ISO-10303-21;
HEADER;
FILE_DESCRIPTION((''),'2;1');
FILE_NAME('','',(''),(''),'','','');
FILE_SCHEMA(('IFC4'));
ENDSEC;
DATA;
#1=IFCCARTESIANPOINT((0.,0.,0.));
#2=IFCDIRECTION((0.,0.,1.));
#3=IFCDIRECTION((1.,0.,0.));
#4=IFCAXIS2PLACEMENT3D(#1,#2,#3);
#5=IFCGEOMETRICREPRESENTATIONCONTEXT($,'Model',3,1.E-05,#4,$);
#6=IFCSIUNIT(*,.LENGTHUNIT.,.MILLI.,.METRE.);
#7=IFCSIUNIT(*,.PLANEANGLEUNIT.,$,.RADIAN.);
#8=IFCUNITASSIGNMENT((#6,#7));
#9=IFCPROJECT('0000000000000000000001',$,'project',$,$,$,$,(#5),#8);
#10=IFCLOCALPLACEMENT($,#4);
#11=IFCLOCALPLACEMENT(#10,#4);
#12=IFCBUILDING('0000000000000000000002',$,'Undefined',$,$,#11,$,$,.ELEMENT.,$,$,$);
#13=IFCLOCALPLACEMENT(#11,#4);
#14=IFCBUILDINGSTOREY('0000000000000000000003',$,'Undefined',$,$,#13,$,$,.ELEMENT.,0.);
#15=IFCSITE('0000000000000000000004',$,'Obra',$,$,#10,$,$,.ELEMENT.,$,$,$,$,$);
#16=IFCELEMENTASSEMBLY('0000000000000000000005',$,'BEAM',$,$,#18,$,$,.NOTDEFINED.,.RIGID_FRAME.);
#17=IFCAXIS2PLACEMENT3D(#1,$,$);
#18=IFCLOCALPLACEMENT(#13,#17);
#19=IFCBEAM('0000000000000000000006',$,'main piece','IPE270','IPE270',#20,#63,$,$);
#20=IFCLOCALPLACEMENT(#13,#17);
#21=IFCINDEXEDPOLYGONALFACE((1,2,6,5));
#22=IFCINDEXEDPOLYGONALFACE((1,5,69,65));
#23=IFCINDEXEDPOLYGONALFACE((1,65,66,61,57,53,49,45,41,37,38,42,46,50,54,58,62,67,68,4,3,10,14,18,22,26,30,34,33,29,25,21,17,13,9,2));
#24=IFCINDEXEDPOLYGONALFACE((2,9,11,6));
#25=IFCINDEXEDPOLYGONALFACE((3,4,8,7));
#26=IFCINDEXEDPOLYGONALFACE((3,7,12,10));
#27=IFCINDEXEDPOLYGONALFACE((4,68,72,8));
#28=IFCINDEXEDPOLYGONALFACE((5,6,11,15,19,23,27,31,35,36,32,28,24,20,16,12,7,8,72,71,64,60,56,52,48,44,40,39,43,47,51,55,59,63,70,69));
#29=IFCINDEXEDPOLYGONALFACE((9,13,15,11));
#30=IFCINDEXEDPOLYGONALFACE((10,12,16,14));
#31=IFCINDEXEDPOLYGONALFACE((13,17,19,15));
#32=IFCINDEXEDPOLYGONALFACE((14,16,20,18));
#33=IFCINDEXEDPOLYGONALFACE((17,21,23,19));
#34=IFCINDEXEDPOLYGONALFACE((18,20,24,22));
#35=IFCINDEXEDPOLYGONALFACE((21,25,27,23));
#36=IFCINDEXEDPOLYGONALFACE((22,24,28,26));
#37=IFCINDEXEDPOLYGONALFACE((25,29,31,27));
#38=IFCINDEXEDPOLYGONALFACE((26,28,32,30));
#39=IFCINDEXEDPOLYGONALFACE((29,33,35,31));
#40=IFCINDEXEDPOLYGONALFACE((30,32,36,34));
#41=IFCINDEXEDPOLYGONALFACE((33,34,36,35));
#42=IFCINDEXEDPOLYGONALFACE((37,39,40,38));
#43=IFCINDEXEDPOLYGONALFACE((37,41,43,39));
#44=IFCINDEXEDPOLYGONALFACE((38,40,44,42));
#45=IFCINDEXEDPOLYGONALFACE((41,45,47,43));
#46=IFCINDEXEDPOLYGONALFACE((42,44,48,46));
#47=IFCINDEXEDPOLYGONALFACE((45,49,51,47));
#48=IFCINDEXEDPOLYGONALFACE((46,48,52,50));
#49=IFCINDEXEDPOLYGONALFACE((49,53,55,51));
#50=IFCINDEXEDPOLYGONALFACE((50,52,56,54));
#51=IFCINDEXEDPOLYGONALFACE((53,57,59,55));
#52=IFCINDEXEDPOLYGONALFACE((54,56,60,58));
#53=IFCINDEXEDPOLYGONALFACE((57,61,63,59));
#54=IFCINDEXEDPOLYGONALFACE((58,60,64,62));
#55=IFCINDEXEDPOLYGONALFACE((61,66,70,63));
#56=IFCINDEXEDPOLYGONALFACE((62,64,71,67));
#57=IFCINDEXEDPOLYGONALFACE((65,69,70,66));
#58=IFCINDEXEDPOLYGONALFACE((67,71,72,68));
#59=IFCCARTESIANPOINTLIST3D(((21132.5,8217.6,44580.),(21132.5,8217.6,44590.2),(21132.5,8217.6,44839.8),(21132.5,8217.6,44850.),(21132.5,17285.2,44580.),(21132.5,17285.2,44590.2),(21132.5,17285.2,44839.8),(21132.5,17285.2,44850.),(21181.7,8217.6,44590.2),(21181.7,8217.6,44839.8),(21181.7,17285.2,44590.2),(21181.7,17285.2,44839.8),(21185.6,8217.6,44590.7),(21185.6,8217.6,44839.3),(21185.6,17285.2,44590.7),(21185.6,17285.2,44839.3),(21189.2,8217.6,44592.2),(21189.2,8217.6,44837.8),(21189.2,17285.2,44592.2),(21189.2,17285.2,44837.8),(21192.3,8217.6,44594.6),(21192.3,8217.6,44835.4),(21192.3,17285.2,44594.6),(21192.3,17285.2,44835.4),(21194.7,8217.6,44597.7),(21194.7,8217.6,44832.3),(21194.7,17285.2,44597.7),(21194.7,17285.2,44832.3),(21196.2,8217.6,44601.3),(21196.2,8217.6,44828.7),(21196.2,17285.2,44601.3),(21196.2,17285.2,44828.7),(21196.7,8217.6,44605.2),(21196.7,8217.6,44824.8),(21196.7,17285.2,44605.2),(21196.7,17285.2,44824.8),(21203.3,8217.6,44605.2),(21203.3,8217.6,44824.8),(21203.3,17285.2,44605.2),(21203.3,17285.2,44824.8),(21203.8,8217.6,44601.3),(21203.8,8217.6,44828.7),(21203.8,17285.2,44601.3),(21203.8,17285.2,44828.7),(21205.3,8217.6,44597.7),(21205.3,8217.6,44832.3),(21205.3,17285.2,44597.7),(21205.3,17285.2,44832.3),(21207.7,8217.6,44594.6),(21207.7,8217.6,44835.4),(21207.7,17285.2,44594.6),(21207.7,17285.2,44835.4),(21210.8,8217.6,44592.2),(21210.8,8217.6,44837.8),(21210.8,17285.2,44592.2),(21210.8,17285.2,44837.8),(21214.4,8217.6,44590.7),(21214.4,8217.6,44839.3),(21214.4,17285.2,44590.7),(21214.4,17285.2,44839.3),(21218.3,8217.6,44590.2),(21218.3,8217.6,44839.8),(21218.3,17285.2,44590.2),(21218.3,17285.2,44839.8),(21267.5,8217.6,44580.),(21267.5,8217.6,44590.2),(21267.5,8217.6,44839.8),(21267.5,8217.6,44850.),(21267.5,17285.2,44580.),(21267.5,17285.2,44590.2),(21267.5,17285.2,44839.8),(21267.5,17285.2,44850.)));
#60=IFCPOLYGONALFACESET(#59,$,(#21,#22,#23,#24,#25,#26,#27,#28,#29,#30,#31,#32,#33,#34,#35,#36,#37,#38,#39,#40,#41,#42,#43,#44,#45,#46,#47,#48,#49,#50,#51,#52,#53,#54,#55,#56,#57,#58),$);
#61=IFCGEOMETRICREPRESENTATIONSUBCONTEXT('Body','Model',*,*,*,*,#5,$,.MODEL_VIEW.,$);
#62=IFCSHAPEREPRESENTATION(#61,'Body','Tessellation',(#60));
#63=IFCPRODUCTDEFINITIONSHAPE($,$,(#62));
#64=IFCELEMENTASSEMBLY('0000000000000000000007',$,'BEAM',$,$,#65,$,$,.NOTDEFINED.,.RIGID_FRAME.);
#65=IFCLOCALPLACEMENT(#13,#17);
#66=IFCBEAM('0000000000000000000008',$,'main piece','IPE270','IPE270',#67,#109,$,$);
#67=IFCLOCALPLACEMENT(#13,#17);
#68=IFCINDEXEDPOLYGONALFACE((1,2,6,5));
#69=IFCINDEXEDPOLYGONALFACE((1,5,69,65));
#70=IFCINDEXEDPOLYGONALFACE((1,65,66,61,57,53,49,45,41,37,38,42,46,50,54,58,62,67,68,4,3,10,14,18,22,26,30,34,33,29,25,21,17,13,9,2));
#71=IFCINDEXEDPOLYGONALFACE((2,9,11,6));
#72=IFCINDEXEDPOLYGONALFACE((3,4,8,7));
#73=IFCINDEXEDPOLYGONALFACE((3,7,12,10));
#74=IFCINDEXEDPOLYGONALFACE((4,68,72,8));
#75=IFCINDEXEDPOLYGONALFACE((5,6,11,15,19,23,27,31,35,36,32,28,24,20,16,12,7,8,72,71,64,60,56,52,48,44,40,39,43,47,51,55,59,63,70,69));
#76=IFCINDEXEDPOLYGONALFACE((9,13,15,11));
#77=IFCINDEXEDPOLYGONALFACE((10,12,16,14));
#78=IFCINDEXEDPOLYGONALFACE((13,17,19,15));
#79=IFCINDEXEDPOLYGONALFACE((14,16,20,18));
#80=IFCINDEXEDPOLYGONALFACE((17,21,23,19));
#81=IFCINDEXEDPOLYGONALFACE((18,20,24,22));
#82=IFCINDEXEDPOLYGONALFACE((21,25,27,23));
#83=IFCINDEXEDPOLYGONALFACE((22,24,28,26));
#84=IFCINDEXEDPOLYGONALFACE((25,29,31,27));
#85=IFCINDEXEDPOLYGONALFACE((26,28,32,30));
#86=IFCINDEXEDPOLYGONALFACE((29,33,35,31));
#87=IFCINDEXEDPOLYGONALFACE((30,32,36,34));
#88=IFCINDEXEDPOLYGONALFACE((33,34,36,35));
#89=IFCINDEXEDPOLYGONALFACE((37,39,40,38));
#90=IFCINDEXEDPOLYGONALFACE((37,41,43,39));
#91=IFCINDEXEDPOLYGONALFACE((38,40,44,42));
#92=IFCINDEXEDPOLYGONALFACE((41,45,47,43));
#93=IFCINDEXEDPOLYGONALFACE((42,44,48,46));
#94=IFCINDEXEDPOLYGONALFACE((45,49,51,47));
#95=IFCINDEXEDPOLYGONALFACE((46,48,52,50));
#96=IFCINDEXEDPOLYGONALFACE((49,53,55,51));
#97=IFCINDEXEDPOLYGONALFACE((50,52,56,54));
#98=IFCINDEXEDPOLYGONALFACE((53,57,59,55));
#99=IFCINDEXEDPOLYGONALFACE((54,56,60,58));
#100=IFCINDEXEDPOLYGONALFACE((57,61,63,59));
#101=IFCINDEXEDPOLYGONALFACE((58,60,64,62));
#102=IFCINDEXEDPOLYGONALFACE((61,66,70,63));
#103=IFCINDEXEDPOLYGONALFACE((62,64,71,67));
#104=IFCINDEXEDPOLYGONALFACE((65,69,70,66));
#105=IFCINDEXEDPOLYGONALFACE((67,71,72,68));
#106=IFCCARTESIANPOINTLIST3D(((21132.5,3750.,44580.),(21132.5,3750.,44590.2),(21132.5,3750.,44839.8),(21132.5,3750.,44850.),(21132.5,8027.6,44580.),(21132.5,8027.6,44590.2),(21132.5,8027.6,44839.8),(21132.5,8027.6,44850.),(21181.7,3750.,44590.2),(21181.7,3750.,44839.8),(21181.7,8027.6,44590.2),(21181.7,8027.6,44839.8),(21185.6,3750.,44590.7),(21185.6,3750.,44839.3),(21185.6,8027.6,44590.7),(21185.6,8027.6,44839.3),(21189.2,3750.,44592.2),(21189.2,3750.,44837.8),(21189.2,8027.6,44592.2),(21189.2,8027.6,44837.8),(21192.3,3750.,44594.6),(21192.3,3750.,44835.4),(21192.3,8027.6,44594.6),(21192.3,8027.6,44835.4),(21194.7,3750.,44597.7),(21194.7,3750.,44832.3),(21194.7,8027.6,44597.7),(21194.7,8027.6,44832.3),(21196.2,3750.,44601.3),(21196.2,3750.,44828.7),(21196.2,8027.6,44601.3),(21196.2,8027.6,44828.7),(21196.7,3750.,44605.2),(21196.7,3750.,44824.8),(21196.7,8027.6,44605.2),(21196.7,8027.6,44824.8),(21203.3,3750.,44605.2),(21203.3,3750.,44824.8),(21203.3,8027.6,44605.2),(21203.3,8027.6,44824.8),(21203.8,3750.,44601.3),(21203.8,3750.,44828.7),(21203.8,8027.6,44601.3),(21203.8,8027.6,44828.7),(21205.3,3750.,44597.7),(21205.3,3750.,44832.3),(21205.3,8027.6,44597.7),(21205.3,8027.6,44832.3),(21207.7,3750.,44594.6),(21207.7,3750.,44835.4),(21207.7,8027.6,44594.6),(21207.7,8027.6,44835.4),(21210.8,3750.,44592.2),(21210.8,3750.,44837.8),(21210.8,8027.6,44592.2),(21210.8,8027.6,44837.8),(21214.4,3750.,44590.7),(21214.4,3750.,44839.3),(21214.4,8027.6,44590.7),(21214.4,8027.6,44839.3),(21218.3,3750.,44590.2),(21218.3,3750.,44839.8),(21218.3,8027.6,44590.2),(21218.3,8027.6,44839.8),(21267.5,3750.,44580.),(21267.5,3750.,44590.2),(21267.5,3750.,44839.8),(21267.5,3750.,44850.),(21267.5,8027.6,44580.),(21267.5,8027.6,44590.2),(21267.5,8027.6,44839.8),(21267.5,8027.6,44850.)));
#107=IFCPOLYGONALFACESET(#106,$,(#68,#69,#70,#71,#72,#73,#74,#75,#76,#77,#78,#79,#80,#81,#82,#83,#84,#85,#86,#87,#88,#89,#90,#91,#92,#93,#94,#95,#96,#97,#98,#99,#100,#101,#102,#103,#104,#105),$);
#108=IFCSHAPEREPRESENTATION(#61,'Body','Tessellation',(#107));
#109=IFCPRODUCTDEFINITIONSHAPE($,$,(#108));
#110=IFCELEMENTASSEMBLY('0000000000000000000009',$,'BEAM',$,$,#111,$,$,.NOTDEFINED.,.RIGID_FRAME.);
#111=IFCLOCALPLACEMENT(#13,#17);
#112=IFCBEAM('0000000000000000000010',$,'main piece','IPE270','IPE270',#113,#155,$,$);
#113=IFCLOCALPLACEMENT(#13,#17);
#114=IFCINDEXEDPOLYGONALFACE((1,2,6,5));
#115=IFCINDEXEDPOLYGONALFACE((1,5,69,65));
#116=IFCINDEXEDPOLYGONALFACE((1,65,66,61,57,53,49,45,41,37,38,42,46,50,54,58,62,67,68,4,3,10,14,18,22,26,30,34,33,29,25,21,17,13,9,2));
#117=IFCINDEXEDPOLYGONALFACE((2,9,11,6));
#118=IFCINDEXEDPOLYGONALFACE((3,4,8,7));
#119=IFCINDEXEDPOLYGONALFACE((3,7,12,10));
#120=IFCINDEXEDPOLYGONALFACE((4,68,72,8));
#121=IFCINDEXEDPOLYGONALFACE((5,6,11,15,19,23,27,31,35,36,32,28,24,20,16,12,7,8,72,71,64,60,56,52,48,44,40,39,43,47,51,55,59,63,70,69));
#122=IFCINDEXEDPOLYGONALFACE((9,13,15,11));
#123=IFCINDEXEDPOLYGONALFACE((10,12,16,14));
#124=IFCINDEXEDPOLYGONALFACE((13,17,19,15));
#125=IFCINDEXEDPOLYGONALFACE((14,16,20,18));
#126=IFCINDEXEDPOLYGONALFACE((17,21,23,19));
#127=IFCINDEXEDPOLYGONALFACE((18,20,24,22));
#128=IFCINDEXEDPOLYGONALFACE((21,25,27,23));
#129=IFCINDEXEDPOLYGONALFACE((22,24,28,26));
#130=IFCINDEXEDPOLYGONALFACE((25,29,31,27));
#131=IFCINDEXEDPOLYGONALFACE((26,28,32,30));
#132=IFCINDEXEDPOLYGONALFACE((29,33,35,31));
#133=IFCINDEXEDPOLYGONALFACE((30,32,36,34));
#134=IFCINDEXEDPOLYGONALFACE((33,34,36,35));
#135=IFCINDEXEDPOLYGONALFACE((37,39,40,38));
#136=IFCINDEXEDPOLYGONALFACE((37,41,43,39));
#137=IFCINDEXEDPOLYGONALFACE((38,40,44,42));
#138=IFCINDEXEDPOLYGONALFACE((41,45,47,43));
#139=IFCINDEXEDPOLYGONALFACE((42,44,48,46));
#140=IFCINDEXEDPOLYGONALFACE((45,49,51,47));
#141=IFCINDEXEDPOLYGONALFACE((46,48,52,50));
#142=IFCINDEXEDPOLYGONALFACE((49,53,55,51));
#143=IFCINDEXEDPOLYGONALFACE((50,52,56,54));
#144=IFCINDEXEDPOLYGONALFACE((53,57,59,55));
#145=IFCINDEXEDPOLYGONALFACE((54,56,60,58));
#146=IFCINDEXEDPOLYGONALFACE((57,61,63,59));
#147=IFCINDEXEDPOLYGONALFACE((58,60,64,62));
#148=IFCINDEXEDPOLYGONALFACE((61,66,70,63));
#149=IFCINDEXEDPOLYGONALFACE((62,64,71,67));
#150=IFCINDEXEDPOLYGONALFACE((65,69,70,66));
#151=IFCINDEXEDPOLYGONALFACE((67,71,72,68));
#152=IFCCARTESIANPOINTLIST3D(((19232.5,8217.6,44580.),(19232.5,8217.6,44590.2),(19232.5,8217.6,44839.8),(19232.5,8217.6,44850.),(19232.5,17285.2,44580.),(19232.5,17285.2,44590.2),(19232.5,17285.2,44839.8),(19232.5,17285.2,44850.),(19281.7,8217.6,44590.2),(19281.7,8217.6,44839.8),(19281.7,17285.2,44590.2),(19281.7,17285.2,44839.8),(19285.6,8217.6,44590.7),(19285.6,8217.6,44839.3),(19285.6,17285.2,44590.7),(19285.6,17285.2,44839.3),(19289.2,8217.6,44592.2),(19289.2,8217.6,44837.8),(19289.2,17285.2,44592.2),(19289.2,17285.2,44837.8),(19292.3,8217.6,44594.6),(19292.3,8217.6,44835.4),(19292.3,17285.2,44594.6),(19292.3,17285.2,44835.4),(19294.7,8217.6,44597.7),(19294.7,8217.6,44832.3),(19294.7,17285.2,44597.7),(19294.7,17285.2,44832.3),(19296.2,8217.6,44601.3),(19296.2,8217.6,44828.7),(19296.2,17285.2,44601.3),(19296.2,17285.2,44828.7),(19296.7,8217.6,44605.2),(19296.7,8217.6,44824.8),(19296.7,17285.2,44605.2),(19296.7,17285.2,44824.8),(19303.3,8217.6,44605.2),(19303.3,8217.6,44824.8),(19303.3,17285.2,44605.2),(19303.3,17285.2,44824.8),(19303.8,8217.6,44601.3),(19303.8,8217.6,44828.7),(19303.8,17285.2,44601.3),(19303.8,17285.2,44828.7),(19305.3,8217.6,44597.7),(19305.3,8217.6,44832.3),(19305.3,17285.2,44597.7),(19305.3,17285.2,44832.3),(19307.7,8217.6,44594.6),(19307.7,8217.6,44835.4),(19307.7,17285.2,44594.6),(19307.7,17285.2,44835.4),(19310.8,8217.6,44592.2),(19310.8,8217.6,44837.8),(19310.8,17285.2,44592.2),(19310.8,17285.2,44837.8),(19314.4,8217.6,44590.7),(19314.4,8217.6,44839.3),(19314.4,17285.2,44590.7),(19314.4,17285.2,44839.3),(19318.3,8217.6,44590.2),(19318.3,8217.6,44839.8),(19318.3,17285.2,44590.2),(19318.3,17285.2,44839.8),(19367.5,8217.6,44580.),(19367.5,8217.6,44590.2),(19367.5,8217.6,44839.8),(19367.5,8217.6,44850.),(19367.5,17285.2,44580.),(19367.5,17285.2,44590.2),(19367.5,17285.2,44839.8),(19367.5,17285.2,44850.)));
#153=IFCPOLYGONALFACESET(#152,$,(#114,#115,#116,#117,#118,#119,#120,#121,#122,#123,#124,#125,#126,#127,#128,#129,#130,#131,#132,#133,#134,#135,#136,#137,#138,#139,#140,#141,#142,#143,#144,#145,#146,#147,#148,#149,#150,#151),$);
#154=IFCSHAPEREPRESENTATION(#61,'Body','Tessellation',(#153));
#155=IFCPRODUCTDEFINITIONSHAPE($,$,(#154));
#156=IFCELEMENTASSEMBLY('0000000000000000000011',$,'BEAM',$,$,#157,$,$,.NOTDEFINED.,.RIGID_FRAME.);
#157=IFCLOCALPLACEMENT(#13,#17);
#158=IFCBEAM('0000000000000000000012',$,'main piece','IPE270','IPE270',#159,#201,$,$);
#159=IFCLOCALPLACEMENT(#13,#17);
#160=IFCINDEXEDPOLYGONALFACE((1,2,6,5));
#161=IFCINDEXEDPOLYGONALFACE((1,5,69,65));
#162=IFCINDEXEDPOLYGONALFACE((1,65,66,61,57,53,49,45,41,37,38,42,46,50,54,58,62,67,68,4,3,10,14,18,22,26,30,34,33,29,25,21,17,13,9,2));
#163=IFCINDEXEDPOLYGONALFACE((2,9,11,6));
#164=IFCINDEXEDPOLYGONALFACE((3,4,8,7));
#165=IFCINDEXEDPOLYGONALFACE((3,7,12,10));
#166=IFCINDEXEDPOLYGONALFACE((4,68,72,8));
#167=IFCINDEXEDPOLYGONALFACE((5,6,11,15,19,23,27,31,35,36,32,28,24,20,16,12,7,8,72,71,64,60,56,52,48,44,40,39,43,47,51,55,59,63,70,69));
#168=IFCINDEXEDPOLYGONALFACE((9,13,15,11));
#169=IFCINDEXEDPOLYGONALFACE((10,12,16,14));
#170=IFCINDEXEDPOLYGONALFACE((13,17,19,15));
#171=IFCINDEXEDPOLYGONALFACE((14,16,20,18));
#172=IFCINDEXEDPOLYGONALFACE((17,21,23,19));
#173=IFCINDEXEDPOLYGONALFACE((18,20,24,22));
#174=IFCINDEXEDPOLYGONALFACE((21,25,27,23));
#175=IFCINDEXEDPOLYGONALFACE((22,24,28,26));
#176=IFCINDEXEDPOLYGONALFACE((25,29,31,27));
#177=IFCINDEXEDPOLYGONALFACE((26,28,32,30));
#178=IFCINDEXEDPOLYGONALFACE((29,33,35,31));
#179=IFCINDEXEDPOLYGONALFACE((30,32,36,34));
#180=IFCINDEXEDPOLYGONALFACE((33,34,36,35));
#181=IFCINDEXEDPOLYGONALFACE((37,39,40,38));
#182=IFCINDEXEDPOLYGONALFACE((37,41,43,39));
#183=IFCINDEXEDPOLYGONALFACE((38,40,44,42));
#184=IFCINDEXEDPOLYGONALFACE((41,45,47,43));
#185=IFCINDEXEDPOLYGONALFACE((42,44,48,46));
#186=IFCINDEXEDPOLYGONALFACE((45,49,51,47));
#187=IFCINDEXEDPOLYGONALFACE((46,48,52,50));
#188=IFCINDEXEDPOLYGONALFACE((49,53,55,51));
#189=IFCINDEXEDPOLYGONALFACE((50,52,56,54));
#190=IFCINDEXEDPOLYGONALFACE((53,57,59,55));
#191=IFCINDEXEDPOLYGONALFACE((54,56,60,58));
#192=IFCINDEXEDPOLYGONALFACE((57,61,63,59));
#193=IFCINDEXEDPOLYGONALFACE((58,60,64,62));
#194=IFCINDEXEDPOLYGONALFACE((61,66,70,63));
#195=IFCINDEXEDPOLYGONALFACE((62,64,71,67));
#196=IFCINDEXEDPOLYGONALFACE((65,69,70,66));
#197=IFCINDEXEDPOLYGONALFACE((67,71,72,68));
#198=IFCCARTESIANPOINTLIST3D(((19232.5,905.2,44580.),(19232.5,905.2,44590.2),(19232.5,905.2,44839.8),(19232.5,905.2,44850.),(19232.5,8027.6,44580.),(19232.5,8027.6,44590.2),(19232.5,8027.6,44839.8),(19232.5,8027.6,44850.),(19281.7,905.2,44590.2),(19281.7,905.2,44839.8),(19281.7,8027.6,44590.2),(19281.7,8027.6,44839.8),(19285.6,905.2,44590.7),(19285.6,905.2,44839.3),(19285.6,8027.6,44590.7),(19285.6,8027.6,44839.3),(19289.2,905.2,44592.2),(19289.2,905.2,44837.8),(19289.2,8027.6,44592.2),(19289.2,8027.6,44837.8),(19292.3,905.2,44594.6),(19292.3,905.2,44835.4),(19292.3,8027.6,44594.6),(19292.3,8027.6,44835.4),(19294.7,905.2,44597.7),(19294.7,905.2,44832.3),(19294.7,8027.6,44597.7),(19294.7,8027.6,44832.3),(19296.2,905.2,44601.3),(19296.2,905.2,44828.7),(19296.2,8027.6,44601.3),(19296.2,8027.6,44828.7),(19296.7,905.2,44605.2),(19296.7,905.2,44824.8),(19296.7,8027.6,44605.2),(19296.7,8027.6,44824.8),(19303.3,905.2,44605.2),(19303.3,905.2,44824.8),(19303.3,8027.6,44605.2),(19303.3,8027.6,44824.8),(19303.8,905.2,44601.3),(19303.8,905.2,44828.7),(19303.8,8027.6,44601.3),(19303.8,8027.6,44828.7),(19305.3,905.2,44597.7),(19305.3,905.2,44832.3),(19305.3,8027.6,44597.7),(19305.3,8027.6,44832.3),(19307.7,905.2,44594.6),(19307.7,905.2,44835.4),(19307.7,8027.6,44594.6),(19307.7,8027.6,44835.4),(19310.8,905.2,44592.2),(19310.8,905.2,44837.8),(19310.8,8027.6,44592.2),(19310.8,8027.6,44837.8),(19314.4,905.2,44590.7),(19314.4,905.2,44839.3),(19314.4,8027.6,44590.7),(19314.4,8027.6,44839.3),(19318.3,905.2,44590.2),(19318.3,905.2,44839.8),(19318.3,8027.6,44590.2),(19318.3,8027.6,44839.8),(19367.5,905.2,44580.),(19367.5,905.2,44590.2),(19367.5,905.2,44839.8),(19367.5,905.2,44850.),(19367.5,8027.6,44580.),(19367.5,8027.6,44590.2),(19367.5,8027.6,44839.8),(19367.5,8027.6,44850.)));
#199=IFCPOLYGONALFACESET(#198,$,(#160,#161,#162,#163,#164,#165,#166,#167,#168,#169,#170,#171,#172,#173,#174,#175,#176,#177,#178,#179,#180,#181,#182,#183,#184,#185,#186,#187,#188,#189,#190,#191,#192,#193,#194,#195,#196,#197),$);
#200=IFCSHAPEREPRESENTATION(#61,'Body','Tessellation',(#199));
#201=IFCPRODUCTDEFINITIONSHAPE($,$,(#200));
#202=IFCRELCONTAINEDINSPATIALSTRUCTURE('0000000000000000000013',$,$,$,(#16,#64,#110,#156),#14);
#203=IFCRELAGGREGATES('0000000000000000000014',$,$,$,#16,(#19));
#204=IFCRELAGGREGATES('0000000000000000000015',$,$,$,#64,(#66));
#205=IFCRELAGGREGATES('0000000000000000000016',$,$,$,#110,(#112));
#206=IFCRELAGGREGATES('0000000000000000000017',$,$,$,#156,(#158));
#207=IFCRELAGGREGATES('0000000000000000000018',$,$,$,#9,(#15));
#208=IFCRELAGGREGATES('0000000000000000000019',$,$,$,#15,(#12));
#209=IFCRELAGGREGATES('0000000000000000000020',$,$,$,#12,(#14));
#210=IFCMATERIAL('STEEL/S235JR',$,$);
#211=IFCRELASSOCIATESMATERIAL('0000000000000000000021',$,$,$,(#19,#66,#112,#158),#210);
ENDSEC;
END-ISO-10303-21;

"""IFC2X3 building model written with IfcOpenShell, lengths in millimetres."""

from ifc_helpers import new_model, si_unit, frame, origin_with_axes, origin_2d_with_axis, place, context, subcontext, project, spatial, i_section, extrude, material, element, aggregate, save


model = new_model("IFC2X3")

# Units and contexts
model_context = context("Model", 3, precision=1e-05, world=origin_with_axes())
body_context = subcontext(model_context, "Body", "Model", "MODEL_VIEW")
ifc_project = project(units=[si_unit("LENGTHUNIT", "METRE", prefix="MILLI"), si_unit("PLANEANGLEUNIT", "RADIAN")], contexts=[model_context])

# Site, building, storey
site_placement = place(None, origin_with_axes())
site = spatial("IfcSite", under=ifc_project, at=site_placement, Name="Obra", CompositionType="ELEMENT")
building_placement = place(site_placement, origin_with_axes())
building = spatial("IfcBuilding", under=site, at=building_placement, Name="Undefined", CompositionType="ELEMENT")
storey_placement = place(building_placement, origin_with_axes())
storey = spatial("IfcBuildingStorey", under=building, at=storey_placement, Name="Undefined", CompositionType="ELEMENT", Elevation=0.0)

# Shared definitions
ifc_material = material(Name="STEEL/S235JR")

# Element assemblies, beams
assembly_1_placement = place(storey_placement, origin_with_axes())
assembly_1 = element("IfcElementAssembly", 1, at=assembly_1_placement, inside=storey, Name="BEAM", AssemblyPlace="NOTDEFINED", PredefinedType="RIGID_FRAME")
beam_1_placement = place(assembly_1_placement, frame((21200.0, 8217.6, 44715.0), z_axis=(0.0, 0.0, 1.0), x_axis=(0.0, 1.0, 0.0)))
beam_1 = element("IfcBeam", 2, at=beam_1_placement, material=ifc_material, Name="main piece", Description="IPE270", ObjectType="IPE270", context=body_context, shape_type="SweptSolid", body=[
    extrude(i_section(OverallWidth=135.0, OverallDepth=270.0, WebThickness=6.6, FlangeThickness=10.2, FilletRadius=15.0, at=origin_2d_with_axis()), frame((9067.6, 0.0, 0.0), z_axis=(-1.0, 0.0, 0.0), x_axis=(0.0, -1.0, 0.0)), (0.0, 0.0, 1.0), 9067.6),
])
aggregate(assembly_1, [beam_1])
assembly_2_placement = place(storey_placement, origin_with_axes())
assembly_2 = element("IfcElementAssembly", 3, at=assembly_2_placement, inside=storey, Name="BEAM", AssemblyPlace="NOTDEFINED", PredefinedType="RIGID_FRAME")
beam_2_placement = place(assembly_2_placement, frame((21200.0, 3750.0, 44715.0), z_axis=(0.0, 0.0, 1.0), x_axis=(0.0, 1.0, 0.0)))
beam_2 = element("IfcBeam", 4, at=beam_2_placement, material=ifc_material, Name="main piece", Description="IPE270", ObjectType="IPE270", context=body_context, shape_type="SweptSolid", body=[
    extrude(i_section(OverallWidth=135.0, OverallDepth=270.0, WebThickness=6.6, FlangeThickness=10.2, FilletRadius=15.0, at=origin_2d_with_axis()), frame((4277.6, 0.0, 0.0), z_axis=(-1.0, 0.0, 0.0), x_axis=(0.0, -1.0, 0.0)), (0.0, 0.0, 1.0), 4277.6),
])
aggregate(assembly_2, [beam_2])
assembly_3_placement = place(storey_placement, origin_with_axes())
assembly_3 = element("IfcElementAssembly", 5, at=assembly_3_placement, inside=storey, Name="BEAM", AssemblyPlace="NOTDEFINED", PredefinedType="RIGID_FRAME")
beam_3_placement = place(assembly_3_placement, frame((19300.0, 8217.6, 44715.0), z_axis=(0.0, 0.0, 1.0), x_axis=(0.0, 1.0, 0.0)))
beam_3 = element("IfcBeam", 6, at=beam_3_placement, material=ifc_material, Name="main piece", Description="IPE270", ObjectType="IPE270", context=body_context, shape_type="SweptSolid", body=[
    extrude(i_section(OverallWidth=135.0, OverallDepth=270.0, WebThickness=6.6, FlangeThickness=10.2, FilletRadius=15.0, at=origin_2d_with_axis()), frame((9067.6, 0.0, 0.0), z_axis=(-1.0, 0.0, 0.0), x_axis=(0.0, -1.0, 0.0)), (0.0, 0.0, 1.0), 9067.6),
])
aggregate(assembly_3, [beam_3])
assembly_4_placement = place(storey_placement, origin_with_axes())
assembly_4 = element("IfcElementAssembly", 7, at=assembly_4_placement, inside=storey, Name="BEAM", AssemblyPlace="NOTDEFINED", PredefinedType="RIGID_FRAME")
beam_4_placement = place(assembly_4_placement, frame((19300.0, 905.2, 44715.0), z_axis=(0.0, 0.0, 1.0), x_axis=(0.0, 1.0, 0.0)))
beam_4 = element("IfcBeam", 8, at=beam_4_placement, material=ifc_material, Name="main piece", Description="IPE270", ObjectType="IPE270", context=body_context, shape_type="SweptSolid", body=[
    extrude(i_section(OverallWidth=135.0, OverallDepth=270.0, WebThickness=6.6, FlangeThickness=10.2, FilletRadius=15.0, at=origin_2d_with_axis()), frame((7122.4, 0.0, 0.0), z_axis=(-1.0, 0.0, 0.0), x_axis=(0.0, -1.0, 0.0)), (0.0, 0.0, 1.0), 7122.4),
])
aggregate(assembly_4, [beam_4])

save(model, "model.ifc")
